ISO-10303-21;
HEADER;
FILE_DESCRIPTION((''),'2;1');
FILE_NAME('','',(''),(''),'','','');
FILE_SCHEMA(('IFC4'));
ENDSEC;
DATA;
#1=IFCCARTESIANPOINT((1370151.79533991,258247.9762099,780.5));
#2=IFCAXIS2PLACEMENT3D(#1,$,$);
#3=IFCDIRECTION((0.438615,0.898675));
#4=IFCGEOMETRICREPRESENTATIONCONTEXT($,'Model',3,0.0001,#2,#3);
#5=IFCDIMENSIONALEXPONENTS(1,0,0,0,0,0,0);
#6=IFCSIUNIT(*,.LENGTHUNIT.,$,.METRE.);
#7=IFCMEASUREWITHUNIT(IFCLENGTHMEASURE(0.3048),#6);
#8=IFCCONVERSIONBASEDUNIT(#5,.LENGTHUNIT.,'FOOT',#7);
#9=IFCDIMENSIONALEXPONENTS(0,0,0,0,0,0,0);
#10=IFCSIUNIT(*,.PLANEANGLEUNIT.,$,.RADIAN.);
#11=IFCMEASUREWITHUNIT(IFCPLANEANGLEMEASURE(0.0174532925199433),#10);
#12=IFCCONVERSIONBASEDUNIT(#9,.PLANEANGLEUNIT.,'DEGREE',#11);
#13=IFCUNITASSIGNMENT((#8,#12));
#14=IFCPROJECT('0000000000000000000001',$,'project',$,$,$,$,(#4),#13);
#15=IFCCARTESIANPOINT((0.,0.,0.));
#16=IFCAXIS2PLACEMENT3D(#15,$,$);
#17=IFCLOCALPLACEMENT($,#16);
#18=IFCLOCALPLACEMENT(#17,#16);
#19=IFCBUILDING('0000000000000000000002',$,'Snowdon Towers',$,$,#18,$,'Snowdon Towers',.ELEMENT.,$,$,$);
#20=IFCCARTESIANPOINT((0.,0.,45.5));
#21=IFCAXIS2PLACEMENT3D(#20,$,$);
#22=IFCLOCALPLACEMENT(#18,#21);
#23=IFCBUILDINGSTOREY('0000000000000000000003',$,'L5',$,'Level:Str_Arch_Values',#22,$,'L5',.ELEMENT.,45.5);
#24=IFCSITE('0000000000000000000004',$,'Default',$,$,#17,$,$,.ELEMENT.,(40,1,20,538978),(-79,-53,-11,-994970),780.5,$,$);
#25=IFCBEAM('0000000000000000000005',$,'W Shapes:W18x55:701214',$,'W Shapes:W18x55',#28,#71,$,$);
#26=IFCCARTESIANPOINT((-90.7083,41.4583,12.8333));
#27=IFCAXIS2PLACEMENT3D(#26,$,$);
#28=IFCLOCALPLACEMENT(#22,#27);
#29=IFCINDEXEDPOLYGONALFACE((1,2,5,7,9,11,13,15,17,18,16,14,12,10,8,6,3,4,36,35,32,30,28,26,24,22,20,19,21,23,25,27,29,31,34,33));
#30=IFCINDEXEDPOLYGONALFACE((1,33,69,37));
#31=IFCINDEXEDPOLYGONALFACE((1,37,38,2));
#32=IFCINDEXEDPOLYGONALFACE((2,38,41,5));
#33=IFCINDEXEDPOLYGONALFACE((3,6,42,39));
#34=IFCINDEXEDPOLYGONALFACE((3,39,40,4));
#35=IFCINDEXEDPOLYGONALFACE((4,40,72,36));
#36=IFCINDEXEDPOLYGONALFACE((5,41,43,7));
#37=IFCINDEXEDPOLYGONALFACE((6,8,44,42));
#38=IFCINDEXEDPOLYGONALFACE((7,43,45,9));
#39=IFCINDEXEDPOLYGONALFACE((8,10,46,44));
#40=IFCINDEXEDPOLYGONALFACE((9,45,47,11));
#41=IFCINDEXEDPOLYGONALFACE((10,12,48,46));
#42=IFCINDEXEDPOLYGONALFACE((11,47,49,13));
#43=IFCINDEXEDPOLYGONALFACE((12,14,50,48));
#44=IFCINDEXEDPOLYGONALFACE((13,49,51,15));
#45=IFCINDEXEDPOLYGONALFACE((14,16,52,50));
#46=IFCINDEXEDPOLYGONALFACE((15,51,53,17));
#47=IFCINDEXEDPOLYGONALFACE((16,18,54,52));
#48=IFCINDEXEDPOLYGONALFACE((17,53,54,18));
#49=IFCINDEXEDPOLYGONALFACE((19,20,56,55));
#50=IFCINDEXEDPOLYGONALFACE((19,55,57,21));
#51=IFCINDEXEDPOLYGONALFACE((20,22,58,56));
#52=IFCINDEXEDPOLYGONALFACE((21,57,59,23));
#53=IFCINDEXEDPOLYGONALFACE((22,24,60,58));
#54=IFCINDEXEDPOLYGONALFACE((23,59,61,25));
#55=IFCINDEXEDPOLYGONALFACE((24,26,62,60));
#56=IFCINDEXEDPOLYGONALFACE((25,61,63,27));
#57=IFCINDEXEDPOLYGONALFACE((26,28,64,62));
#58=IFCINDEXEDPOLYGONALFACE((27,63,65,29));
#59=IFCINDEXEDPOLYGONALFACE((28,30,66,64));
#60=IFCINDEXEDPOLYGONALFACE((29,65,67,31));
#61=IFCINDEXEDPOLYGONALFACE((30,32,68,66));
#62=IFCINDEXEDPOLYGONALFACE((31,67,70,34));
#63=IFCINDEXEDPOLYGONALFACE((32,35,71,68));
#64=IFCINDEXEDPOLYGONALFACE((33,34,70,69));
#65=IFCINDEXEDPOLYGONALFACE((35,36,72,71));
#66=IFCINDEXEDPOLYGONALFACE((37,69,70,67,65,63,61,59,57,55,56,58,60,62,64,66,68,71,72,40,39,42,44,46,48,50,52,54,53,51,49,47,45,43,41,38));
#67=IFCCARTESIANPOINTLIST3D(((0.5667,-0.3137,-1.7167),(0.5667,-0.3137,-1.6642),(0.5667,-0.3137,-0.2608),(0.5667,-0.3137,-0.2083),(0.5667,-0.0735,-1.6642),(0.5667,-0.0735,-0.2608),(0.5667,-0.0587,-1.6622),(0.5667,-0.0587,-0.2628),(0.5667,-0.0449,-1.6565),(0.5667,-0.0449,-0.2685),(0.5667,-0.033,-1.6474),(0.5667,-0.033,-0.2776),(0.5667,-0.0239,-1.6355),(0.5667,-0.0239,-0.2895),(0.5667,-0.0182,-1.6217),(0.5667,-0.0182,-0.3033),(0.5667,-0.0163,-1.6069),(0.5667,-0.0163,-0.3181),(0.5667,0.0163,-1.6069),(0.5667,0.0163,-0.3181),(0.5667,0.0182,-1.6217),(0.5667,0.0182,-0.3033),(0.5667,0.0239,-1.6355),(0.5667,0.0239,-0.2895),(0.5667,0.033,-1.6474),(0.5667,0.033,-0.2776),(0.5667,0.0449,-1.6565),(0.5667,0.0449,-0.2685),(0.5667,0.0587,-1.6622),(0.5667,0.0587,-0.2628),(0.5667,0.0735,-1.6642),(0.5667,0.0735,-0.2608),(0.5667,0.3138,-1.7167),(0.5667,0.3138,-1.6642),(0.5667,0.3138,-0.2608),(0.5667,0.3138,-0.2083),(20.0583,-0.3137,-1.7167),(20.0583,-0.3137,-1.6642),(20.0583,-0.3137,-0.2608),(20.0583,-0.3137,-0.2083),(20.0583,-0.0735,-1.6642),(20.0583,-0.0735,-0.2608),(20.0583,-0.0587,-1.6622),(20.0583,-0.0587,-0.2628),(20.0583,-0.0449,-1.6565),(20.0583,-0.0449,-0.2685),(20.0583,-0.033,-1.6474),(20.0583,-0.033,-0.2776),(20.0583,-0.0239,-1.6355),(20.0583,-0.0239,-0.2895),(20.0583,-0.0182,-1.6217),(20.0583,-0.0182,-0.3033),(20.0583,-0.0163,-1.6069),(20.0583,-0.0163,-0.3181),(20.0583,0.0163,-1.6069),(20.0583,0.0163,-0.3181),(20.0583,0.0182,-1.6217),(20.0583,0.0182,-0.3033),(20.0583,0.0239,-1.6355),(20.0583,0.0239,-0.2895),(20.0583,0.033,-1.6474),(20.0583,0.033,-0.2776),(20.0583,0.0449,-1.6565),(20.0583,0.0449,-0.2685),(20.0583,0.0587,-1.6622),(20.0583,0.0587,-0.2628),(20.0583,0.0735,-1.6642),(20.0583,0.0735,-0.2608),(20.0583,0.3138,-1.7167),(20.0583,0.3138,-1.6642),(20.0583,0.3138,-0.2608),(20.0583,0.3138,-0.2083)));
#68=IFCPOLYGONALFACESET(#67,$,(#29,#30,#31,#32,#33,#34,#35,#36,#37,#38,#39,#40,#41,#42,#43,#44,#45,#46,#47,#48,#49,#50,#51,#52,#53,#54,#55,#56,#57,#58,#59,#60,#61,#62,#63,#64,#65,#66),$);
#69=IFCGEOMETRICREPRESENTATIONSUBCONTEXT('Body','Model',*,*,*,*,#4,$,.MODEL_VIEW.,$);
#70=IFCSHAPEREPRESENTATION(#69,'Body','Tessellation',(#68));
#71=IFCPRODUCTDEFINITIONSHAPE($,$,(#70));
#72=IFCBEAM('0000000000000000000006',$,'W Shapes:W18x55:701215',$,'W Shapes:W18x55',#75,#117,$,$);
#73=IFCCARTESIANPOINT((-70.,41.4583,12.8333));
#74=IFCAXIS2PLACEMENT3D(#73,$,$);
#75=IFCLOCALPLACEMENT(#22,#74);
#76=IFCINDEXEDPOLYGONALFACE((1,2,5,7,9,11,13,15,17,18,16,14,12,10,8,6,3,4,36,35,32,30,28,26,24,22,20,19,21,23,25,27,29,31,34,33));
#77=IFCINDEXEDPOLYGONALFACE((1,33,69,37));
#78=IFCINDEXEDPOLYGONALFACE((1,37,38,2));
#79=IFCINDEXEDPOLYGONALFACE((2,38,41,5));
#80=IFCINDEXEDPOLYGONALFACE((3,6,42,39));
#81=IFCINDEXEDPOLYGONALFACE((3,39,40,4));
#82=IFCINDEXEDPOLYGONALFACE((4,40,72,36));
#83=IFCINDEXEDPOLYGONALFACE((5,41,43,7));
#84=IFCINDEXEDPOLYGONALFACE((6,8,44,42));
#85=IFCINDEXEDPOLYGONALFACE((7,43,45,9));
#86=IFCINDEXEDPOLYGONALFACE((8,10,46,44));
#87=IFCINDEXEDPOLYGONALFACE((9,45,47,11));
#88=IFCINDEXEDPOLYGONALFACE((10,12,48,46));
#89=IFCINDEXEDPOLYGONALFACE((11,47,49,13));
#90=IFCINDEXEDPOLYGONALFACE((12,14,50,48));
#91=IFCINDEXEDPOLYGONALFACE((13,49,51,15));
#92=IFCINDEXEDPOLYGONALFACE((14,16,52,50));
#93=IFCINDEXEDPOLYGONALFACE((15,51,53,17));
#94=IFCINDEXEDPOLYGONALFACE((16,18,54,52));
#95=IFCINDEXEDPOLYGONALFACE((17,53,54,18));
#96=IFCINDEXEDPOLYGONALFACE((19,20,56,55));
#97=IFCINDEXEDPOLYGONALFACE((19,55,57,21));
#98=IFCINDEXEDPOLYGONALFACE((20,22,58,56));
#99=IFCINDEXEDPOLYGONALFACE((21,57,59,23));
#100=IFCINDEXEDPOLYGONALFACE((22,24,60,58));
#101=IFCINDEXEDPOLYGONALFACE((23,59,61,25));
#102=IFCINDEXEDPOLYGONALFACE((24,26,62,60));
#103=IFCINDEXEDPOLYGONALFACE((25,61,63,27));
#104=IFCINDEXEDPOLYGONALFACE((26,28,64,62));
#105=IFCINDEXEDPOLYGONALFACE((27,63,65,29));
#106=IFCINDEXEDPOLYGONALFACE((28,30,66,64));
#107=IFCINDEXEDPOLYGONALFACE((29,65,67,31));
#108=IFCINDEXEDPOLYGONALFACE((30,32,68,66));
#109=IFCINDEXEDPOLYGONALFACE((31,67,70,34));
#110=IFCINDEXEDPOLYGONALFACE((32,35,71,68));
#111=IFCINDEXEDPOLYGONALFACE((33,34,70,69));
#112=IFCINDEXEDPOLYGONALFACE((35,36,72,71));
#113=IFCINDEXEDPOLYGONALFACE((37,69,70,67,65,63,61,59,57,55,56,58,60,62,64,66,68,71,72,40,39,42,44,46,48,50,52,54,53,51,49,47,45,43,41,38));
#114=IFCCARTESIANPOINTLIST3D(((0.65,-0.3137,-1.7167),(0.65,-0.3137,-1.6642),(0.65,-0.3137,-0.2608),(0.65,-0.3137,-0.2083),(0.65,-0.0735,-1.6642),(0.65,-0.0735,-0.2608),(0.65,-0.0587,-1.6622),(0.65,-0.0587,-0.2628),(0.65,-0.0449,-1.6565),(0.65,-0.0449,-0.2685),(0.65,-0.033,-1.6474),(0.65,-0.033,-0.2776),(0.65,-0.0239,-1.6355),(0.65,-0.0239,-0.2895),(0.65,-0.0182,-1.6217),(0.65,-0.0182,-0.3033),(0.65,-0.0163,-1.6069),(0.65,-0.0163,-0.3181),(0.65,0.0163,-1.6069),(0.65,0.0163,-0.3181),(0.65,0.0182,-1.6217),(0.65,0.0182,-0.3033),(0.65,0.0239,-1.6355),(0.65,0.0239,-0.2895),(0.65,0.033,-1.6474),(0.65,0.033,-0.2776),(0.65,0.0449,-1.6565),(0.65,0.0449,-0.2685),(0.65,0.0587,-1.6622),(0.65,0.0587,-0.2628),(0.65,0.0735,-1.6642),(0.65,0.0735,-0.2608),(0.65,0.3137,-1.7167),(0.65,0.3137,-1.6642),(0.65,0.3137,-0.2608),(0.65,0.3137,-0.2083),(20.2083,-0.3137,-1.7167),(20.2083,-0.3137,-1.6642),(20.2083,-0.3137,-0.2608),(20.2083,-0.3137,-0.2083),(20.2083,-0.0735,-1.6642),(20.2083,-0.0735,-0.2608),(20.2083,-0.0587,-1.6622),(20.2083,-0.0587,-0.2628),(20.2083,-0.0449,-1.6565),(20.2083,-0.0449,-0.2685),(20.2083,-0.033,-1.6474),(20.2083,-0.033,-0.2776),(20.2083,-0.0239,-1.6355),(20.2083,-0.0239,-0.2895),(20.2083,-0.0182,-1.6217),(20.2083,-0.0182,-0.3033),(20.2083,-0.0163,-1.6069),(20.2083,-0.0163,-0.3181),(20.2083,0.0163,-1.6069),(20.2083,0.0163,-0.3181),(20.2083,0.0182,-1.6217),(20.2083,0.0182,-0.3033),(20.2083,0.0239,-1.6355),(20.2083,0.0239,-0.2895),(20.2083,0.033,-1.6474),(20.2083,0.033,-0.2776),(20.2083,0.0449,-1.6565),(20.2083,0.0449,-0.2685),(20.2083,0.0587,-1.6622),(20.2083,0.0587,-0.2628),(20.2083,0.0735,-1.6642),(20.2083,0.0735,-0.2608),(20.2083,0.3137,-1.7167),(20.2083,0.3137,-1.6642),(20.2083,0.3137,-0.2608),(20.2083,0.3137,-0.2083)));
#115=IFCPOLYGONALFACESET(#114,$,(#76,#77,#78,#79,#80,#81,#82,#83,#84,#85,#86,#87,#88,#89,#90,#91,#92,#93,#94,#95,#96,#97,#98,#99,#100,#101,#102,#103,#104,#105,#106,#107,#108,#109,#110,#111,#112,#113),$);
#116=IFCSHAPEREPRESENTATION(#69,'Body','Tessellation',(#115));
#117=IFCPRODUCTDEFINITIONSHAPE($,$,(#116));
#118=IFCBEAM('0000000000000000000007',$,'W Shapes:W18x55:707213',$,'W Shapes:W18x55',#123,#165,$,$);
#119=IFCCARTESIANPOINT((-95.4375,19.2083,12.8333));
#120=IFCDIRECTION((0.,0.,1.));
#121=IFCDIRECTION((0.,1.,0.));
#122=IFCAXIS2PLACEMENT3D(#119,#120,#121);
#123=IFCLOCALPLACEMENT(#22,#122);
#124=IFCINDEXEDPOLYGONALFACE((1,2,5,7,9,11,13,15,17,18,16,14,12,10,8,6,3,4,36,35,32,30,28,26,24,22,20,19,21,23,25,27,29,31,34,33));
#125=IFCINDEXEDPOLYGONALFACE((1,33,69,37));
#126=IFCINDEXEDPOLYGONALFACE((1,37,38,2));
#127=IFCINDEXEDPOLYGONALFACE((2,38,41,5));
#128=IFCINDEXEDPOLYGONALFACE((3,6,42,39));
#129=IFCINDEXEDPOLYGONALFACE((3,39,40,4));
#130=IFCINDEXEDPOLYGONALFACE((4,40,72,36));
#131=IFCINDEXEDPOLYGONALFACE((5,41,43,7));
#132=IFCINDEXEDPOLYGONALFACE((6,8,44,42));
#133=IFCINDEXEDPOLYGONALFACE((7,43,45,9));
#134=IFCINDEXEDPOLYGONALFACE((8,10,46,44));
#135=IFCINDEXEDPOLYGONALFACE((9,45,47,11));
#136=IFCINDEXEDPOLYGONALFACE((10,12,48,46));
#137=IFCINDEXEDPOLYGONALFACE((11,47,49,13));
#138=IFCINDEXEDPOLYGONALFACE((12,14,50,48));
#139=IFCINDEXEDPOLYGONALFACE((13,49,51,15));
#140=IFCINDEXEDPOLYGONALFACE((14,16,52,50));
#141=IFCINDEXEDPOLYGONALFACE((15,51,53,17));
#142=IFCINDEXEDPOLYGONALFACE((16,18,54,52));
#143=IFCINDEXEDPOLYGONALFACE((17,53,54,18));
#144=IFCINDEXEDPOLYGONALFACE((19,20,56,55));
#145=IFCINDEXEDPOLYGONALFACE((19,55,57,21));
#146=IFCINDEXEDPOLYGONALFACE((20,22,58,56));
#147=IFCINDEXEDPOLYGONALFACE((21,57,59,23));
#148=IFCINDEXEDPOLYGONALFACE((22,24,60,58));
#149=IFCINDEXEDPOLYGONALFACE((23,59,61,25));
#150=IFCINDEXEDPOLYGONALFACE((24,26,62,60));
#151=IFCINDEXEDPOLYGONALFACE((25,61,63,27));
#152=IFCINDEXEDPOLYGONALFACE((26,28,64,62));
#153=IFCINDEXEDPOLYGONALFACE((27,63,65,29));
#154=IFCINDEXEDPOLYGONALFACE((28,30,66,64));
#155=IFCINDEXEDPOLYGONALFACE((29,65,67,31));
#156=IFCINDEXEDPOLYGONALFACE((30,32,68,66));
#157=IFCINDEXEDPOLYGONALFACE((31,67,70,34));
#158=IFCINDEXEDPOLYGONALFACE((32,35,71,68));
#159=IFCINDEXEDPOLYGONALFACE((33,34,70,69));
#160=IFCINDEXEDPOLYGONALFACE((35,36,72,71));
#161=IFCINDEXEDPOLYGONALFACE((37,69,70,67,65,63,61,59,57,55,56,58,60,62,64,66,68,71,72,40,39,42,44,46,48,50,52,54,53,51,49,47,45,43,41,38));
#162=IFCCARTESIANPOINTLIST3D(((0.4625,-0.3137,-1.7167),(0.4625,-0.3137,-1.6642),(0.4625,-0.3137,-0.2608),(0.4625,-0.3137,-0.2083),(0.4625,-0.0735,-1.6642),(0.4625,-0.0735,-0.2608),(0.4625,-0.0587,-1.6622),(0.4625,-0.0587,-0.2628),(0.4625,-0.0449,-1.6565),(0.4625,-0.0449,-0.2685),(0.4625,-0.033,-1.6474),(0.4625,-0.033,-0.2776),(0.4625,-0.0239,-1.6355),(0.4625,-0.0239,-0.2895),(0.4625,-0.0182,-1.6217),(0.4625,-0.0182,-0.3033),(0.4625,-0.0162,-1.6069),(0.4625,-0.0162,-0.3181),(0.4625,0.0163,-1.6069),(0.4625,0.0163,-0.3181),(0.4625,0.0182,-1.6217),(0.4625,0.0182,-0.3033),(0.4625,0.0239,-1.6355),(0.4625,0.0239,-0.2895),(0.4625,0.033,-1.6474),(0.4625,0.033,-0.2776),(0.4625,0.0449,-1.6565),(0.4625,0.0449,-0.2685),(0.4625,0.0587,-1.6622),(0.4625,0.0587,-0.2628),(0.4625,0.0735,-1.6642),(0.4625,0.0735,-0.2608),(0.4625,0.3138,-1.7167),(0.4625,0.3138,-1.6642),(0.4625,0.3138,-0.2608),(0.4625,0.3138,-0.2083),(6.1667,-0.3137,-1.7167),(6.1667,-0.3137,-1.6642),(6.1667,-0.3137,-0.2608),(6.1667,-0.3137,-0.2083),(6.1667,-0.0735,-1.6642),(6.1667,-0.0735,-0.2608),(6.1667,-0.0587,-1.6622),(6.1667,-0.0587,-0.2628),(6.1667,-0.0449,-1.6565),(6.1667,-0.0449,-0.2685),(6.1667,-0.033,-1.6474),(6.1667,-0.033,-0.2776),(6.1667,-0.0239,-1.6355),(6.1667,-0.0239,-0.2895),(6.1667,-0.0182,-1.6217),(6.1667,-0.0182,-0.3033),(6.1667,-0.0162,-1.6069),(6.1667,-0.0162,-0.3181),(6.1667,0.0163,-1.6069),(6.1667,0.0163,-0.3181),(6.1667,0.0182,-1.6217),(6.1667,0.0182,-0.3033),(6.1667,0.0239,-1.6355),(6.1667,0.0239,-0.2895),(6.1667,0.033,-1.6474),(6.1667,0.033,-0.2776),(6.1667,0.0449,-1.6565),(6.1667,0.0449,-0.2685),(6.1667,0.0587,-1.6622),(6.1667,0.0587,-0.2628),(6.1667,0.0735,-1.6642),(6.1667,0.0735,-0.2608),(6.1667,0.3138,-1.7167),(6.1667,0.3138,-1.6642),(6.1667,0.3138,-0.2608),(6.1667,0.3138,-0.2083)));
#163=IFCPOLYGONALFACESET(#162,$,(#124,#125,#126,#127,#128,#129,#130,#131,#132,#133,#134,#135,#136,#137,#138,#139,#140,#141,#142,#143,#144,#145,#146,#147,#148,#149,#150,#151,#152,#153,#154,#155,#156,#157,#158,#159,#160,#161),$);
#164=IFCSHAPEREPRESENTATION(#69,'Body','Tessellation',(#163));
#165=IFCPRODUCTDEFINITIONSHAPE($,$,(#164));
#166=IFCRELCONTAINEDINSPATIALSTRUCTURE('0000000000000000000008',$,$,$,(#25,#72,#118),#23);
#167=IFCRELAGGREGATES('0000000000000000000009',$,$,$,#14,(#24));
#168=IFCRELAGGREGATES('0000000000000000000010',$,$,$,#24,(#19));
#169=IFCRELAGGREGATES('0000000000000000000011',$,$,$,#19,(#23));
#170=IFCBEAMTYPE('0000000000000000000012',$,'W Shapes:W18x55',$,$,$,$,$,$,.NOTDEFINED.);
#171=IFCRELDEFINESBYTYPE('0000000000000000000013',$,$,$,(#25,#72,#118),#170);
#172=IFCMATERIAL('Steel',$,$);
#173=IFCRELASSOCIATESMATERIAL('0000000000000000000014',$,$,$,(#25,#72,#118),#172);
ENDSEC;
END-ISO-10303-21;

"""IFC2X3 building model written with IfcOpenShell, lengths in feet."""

from ifc_helpers import new_model, entity, si_unit, converted_unit, direction, frame, frame_2d, origin, place, context, subcontext, project, spatial, i_section, extrude, material, type_object, element, save


model = new_model("IFC2X3")

# Units and contexts
model_context = context("Model", 3, precision=0.0001, world=frame((1370151.79533991, 258247.9762099, 780.5)), true_north=direction((0.438615, 0.898675)))
body_context = subcontext(model_context, "Body", "Model", "MODEL_VIEW")
ifc_project = project(units=[converted_unit("LENGTHUNIT", "FOOT", entity("IfcLengthMeasure", 0.3048), si_unit("LENGTHUNIT", "METRE"), dimensions=[1, 0, 0, 0, 0, 0, 0]), converted_unit("PLANEANGLEUNIT", "DEGREE", entity("IfcPlaneAngleMeasure", 0.0174532925199433), si_unit("PLANEANGLEUNIT", "RADIAN"), dimensions=[0, 0, 0, 0, 0, 0, 0])], contexts=[model_context])

# Site, building, storey
site_placement = place(None, origin())
site = spatial("IfcSite", under=ifc_project, at=site_placement, Name="Default", CompositionType="ELEMENT", RefLatitude=(40, 1, 20, 538978), RefLongitude=(-79, -53, -11, -994970), RefElevation=780.5)
building_placement = place(site_placement, origin())
building = spatial("IfcBuilding", under=site, at=building_placement, Name="Snowdon Towers", LongName="Snowdon Towers", CompositionType="ELEMENT")
storey_placement = place(building_placement, frame((0.0, 0.0, 45.5)))
storey = spatial("IfcBuildingStorey", under=building, at=storey_placement, Name="L5", ObjectType="Level:Str_Arch_Values", LongName="L5", CompositionType="ELEMENT", Elevation=45.5)

# Beams
ifc_material = material(Name="Steel")
beam_type_1 = type_object("IfcBeamType", Name="W Shapes:W18x55", PredefinedType="NOTDEFINED")
beam_1_placement = place(storey_placement, frame((-90.7083, 41.4583, 12.8333)))
element("IfcBeam", 1, at=beam_1_placement, inside=storey, type_object=beam_type_1, material=ifc_material, Name="W Shapes:W18x55:701214", ObjectType="W Shapes:W18x55", context=body_context, shape_type="SweptSolid", body=[
    extrude(i_section(OverallWidth=0.6275, OverallDepth=1.5083, WebThickness=0.0325, FlangeThickness=0.0525, FilletRadius=0.0573, at=frame_2d((0.0, 0.0), x_axis=(0.0, 1.0))), frame((0.5667, 0.0, -0.9625), z_axis=(1.0, 0.0, 0.0), x_axis=(0.0, 0.0, -1.0)), (0.0, 0.0, 1.0), 19.4917),
])
beam_2_placement = place(storey_placement, frame((-70.0, 41.4583, 12.8333)))
element("IfcBeam", 2, at=beam_2_placement, inside=storey, type_object=beam_type_1, material=ifc_material, Name="W Shapes:W18x55:701215", ObjectType="W Shapes:W18x55", context=body_context, shape_type="SweptSolid", body=[
    extrude(i_section(OverallWidth=0.6275, OverallDepth=1.5083, WebThickness=0.0325, FlangeThickness=0.0525, FilletRadius=0.0573, at=frame_2d((0.0, 0.0), x_axis=(0.0, 1.0))), frame((0.65, 0.0, -0.9625), z_axis=(1.0, 0.0, 0.0), x_axis=(0.0, 0.0, -1.0)), (0.0, 0.0, 1.0), 19.5583),
])
beam_3_placement = place(storey_placement, frame((-95.4375, 19.2083, 12.8333), z_axis=(0.0, 0.0, 1.0), x_axis=(0.0, 1.0, 0.0)))
element("IfcBeam", 3, at=beam_3_placement, inside=storey, type_object=beam_type_1, material=ifc_material, Name="W Shapes:W18x55:707213", ObjectType="W Shapes:W18x55", context=body_context, shape_type="SweptSolid", body=[
    extrude(i_section(OverallWidth=0.6275, OverallDepth=1.5083, WebThickness=0.0325, FlangeThickness=0.0525, FilletRadius=0.0573, at=frame_2d((0.0, 0.0), x_axis=(0.0, 1.0))), frame((0.4625, 0.0, -0.9625), z_axis=(1.0, 0.0, 0.0), x_axis=(0.0, 0.0, -1.0)), (0.0, 0.0, 1.0), 5.7042),
])

save(model, "model.ifc")
